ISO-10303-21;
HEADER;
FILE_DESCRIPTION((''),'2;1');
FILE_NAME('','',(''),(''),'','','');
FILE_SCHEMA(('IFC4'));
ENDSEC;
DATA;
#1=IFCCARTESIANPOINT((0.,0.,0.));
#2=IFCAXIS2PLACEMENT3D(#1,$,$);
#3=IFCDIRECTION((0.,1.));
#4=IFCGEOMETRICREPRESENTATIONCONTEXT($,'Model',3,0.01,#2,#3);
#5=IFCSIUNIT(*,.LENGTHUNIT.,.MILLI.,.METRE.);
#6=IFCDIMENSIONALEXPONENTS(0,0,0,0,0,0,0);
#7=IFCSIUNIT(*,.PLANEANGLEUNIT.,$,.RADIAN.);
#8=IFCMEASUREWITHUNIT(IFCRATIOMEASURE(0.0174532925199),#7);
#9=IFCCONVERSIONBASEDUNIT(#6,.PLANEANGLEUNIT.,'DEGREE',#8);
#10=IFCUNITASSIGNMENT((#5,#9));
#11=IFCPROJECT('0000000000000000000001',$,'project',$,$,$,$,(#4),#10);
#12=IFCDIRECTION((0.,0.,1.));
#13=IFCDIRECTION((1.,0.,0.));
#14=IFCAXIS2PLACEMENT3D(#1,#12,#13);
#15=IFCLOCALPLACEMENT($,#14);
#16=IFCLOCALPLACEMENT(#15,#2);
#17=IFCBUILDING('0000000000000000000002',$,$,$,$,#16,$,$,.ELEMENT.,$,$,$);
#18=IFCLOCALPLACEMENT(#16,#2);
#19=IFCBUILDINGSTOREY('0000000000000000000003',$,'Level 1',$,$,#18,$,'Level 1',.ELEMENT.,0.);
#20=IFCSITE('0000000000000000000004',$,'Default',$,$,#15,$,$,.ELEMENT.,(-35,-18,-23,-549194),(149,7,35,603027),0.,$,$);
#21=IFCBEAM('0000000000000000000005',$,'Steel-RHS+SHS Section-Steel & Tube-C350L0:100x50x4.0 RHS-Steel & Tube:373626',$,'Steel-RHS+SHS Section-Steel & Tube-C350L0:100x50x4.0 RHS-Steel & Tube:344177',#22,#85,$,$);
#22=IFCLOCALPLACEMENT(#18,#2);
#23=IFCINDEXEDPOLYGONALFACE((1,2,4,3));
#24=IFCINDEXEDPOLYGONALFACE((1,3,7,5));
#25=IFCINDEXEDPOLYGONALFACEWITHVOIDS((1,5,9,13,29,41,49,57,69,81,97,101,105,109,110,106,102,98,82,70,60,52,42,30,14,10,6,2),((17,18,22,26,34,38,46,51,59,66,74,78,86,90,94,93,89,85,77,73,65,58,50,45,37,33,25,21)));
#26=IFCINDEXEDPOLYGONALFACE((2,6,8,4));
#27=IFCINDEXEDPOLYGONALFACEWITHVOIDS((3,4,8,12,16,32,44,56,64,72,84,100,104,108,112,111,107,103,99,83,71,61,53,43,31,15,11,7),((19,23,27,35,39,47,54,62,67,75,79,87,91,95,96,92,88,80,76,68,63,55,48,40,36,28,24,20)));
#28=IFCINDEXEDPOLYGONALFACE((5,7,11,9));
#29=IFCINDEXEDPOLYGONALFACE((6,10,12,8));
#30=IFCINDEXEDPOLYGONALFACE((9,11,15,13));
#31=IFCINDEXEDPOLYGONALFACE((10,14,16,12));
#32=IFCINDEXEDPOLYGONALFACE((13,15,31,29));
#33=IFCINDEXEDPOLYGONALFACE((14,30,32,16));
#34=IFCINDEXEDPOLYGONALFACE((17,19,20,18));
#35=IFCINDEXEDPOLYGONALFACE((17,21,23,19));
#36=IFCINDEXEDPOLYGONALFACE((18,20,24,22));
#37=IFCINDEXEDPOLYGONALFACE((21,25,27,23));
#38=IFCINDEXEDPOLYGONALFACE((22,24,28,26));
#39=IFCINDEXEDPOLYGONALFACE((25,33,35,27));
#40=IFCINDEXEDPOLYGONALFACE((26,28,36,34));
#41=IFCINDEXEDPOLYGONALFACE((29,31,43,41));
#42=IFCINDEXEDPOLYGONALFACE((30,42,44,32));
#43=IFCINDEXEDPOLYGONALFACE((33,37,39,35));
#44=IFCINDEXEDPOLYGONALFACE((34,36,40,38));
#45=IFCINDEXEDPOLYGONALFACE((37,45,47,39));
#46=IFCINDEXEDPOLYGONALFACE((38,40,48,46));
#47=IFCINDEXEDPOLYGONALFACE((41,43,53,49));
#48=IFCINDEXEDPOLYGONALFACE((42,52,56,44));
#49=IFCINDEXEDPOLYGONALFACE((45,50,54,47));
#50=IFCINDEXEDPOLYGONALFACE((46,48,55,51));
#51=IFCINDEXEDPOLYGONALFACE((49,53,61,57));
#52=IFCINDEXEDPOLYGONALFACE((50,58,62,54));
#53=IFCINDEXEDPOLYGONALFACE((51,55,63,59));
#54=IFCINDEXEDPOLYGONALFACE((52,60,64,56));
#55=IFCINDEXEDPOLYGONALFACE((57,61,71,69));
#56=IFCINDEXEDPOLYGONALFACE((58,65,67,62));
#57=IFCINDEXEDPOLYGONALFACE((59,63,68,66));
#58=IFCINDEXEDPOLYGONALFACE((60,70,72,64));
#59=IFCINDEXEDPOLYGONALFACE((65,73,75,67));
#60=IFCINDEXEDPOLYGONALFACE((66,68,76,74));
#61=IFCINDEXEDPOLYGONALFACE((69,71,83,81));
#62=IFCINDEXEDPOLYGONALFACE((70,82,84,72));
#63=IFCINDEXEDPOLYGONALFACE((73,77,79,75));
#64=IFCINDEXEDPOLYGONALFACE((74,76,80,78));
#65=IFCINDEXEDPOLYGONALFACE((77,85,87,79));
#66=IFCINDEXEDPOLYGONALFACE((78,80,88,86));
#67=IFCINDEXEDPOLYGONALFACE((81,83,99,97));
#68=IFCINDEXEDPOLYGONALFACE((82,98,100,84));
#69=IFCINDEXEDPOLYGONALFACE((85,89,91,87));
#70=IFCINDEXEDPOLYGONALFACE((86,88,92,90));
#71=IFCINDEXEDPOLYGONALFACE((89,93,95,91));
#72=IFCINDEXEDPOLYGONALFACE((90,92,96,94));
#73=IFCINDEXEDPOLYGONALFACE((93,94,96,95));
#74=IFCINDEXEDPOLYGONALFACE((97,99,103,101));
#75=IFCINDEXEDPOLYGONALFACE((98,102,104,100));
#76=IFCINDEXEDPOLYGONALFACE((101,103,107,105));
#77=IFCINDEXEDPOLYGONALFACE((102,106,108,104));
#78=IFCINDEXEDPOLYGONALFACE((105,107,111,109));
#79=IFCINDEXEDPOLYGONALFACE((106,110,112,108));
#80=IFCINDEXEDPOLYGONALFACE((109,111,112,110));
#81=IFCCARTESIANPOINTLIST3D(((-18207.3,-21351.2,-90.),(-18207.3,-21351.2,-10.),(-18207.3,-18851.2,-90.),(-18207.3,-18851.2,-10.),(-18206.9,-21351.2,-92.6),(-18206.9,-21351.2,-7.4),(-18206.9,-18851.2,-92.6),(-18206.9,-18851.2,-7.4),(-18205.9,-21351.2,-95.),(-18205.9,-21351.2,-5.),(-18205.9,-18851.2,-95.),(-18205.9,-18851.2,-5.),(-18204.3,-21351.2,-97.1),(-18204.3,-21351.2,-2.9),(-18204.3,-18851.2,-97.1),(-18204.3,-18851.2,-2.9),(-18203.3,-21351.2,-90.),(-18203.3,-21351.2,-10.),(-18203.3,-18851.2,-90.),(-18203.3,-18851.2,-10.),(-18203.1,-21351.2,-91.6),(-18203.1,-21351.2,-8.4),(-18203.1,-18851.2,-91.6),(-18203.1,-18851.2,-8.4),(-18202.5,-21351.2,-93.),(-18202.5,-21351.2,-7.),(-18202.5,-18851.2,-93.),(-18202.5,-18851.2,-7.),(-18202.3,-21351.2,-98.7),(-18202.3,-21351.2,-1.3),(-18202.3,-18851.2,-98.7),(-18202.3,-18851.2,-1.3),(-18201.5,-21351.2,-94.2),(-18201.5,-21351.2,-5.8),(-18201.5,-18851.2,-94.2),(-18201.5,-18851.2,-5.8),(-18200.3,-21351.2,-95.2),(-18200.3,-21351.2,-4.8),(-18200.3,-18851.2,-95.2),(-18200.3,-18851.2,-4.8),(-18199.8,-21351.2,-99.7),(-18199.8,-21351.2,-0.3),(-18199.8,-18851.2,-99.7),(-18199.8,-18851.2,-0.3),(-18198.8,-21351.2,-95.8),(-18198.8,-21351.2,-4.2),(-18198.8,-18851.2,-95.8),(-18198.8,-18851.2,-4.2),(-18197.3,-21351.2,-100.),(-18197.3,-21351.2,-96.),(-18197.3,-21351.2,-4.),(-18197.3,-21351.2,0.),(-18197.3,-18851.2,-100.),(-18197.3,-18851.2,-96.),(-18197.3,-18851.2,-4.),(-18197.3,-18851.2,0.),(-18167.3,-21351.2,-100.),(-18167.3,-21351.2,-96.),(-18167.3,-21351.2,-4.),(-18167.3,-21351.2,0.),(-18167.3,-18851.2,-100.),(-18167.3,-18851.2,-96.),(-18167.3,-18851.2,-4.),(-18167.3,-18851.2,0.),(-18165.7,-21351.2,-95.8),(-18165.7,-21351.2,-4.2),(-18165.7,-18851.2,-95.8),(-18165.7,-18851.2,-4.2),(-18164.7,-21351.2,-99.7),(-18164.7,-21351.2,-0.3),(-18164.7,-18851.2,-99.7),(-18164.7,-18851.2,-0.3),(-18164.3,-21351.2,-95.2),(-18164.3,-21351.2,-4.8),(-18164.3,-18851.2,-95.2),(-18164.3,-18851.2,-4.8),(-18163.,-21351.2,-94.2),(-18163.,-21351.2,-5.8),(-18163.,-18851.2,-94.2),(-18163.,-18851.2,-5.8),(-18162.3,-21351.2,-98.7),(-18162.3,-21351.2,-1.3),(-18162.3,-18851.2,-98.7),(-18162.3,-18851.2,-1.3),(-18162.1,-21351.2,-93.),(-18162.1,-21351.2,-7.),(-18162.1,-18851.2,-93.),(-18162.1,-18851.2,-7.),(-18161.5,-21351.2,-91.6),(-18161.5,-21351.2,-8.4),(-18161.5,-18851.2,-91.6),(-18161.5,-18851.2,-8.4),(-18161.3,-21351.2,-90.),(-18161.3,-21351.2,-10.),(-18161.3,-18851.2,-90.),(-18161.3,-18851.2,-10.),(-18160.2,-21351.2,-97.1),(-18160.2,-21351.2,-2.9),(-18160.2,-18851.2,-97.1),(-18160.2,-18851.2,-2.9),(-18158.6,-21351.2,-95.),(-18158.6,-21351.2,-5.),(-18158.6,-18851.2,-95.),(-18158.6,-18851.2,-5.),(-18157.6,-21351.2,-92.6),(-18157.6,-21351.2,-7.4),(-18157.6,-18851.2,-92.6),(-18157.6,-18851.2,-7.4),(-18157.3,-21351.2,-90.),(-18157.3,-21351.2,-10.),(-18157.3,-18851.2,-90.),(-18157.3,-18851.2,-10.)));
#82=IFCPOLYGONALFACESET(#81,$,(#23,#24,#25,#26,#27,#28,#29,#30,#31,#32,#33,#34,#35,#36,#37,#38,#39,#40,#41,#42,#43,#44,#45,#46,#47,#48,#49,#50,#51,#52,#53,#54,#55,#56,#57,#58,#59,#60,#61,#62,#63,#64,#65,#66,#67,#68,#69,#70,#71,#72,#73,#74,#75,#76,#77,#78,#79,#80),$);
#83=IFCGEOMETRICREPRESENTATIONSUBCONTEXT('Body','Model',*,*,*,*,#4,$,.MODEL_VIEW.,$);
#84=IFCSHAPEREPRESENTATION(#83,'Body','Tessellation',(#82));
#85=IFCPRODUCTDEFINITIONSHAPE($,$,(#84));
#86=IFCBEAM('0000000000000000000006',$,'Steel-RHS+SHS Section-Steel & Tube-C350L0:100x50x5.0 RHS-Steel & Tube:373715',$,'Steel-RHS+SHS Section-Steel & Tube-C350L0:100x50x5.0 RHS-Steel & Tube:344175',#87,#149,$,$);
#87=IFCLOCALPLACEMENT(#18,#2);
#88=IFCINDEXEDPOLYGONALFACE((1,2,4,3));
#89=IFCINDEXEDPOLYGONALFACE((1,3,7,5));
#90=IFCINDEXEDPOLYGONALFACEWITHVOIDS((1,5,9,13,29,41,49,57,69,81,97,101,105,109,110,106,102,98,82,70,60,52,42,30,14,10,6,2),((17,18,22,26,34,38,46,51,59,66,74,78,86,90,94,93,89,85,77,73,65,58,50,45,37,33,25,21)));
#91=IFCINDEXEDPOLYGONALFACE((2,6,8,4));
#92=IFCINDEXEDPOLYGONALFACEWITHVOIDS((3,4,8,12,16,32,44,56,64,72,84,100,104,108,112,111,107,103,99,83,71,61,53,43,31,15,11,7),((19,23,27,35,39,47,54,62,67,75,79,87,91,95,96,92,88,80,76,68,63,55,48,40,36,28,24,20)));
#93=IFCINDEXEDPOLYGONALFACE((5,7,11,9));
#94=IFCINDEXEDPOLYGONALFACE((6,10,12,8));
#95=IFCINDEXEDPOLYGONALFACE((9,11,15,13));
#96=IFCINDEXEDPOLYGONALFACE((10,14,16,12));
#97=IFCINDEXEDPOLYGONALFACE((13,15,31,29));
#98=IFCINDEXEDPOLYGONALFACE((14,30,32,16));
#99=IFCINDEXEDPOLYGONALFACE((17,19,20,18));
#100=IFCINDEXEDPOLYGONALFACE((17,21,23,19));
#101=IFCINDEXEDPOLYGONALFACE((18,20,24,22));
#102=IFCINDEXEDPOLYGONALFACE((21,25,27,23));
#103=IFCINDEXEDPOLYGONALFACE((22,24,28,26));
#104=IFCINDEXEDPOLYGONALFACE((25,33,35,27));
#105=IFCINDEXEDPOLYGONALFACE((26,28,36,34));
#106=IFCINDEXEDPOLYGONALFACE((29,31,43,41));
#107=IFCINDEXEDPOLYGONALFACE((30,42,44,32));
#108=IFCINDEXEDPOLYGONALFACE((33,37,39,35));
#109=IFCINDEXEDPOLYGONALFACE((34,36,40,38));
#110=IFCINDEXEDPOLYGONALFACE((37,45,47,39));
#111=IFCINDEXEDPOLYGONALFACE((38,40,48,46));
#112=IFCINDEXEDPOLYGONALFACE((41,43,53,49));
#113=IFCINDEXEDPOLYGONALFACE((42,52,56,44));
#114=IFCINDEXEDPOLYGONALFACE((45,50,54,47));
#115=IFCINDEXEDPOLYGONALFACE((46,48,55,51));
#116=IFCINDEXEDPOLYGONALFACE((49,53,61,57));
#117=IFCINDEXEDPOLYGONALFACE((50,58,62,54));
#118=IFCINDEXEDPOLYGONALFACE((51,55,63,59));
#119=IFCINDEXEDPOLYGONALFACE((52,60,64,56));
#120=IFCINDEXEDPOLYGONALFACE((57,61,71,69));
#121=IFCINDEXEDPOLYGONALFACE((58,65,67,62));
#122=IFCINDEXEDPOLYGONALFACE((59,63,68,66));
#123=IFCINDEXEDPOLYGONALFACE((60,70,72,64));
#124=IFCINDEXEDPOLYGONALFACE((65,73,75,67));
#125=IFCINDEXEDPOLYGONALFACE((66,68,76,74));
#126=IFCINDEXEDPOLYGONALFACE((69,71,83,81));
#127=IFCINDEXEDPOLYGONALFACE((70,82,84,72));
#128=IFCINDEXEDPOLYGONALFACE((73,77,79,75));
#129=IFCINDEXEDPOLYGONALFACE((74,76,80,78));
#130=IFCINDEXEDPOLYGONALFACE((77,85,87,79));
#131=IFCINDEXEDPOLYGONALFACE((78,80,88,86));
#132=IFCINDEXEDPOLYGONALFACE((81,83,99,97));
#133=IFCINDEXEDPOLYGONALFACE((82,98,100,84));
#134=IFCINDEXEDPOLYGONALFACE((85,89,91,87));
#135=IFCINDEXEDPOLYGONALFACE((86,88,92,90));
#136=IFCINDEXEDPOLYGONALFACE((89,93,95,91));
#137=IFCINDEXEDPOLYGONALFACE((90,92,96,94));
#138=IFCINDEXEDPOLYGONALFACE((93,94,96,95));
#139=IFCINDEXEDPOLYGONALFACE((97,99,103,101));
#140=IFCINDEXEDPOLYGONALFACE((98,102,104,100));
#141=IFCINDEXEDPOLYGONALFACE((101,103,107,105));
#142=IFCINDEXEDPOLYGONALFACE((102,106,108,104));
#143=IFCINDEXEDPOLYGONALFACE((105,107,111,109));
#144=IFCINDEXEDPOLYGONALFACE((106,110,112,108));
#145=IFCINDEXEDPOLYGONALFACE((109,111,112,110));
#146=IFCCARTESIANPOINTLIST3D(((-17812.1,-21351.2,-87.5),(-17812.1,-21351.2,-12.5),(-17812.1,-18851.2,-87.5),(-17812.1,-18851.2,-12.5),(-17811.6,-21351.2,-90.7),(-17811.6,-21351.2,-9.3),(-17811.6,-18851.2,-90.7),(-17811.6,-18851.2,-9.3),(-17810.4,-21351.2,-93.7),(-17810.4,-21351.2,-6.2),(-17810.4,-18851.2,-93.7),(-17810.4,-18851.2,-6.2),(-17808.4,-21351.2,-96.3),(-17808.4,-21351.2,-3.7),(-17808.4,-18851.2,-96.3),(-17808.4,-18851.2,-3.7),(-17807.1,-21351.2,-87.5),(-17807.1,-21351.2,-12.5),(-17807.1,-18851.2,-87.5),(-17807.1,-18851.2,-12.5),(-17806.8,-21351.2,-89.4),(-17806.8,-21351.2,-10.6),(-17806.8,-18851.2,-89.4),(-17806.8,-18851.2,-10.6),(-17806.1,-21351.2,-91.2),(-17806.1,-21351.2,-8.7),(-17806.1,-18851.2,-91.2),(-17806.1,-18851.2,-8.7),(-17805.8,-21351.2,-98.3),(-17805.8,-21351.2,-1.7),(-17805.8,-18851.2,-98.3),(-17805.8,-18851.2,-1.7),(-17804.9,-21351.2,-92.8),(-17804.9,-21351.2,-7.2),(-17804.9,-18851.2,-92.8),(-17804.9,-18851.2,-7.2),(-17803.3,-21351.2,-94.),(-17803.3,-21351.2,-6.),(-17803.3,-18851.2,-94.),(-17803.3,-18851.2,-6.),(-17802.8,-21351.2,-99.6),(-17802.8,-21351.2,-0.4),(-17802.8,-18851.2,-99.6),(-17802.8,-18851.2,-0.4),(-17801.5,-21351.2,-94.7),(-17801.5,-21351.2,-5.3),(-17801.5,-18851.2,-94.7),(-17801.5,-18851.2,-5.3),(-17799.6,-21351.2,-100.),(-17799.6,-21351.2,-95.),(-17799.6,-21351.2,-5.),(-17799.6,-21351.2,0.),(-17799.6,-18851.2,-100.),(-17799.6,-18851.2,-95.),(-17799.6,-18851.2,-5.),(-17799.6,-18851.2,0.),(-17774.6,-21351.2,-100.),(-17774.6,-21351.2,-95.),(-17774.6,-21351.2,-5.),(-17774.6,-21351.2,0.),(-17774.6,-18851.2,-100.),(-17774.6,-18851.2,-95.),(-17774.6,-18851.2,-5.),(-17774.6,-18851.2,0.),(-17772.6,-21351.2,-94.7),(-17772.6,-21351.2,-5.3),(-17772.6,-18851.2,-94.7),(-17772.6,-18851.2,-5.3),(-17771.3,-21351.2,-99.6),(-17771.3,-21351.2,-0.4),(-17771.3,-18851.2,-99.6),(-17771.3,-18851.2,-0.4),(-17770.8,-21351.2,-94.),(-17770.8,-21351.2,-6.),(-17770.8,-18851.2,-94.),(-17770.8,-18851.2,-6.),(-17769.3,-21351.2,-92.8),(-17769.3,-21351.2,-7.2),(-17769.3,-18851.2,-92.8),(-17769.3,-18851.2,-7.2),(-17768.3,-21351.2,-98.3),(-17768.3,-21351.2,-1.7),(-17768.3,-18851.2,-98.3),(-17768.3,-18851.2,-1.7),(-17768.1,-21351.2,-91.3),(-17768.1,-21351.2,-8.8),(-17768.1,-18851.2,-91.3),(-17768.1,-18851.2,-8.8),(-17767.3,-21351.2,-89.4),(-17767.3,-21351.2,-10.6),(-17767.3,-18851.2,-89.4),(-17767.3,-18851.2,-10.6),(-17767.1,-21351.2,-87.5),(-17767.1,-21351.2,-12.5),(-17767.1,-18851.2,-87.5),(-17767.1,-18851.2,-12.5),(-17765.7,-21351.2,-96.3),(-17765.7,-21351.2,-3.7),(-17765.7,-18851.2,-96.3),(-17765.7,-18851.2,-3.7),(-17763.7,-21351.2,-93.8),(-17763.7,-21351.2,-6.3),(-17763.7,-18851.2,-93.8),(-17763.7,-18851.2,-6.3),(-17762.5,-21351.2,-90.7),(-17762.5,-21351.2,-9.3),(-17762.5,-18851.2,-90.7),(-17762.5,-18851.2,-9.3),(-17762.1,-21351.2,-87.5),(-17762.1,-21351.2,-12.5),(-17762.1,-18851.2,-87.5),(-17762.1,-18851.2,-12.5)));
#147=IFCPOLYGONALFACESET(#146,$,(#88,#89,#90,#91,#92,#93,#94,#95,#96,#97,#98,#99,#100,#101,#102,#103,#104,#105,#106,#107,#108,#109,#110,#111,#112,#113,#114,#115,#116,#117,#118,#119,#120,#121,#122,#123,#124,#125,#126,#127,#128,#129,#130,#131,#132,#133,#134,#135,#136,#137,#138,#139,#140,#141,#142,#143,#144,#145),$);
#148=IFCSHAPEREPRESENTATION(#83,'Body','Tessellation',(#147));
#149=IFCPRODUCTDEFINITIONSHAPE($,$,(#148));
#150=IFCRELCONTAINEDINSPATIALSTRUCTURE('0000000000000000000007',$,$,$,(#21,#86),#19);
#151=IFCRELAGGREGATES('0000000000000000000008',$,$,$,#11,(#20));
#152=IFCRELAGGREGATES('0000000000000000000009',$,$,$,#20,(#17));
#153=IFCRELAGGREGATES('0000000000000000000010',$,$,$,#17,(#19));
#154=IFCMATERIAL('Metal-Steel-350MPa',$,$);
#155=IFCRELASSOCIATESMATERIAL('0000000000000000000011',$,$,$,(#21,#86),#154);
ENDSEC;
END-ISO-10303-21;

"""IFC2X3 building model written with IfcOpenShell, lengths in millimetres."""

from ifc_helpers import new_model, entity, si_unit, converted_unit, direction, frame, frame_2d, origin, origin_with_axes, place, context, subcontext, project, spatial, polyline, circle_curve, parameter, trimmed, segment, composite_curve, outline, extrude, material, element, save


model = new_model("IFC2X3")

# Units and contexts
model_context = context("Model", 3, precision=0.01, world=origin(), true_north=direction((0.0, 1.0)))
body_context = subcontext(model_context, "Body", "Model", "MODEL_VIEW")
ifc_project = project(units=[si_unit("LENGTHUNIT", "METRE", prefix="MILLI"), converted_unit("PLANEANGLEUNIT", "DEGREE", entity("IfcRatioMeasure", 0.0174532925199), si_unit("PLANEANGLEUNIT", "RADIAN"), dimensions=[0, 0, 0, 0, 0, 0, 0])], contexts=[model_context])

# Site, building, storey
site_placement = place(None, origin_with_axes())
site = spatial("IfcSite", under=ifc_project, at=site_placement, Name="Default", CompositionType="ELEMENT", RefLatitude=(-35, -18, -23, -549194), RefLongitude=(149, 7, 35, 603027), RefElevation=0.0)
building_placement = place(site_placement, origin())
building = spatial("IfcBuilding", under=site, at=building_placement, CompositionType="ELEMENT")
storey_placement = place(building_placement, origin())
storey = spatial("IfcBuildingStorey", under=building, at=storey_placement, Name="Level 1", LongName="Level 1", CompositionType="ELEMENT", Elevation=0.0)

# Beams
ifc_material = material(Name="Metal-Steel-350MPa")
beam_1_placement = place(storey_placement, frame((-18182.3, -18851.2, 0.0), z_axis=(0.0, 0.0, 1.0), x_axis=(0.0, -1.0, 0.0)))
element("IfcBeam", 1, at=beam_1_placement, inside=storey, material=ifc_material, Name="Steel-RHS+SHS Section-Steel & Tube-C350L0:100x50x4.0 RHS-Steel & Tube:373626", ObjectType="Steel-RHS+SHS Section-Steel & Tube-C350L0:100x50x4.0 RHS-Steel & Tube:344177", context=body_context, shape_type="SweptSolid", body=[
    extrude(outline(composite_curve([segment(trimmed(circle_curve(frame_2d((-15.0, -40.0), x_axis=(1.0, 0.0)), 10.0), [parameter(180.0)], [parameter(270.0)], True, "PARAMETER"), True, "CONTINUOUS"), segment(polyline([(-15.0, -50.0), (15.0, -50.0)]), True, "CONTINUOUS"), segment(trimmed(circle_curve(frame_2d((15.0, -40.0), x_axis=(1.0, 0.0)), 10.0), [parameter(270.0)], [parameter(0.0)], True, "PARAMETER"), True, "CONTINUOUS"), segment(polyline([(25.0, -40.0), (25.0, 40.0)]), True, "CONTINUOUS"), segment(trimmed(circle_curve(frame_2d((15.0, 40.0), x_axis=(1.0, 0.0)), 10.0), [parameter(0.0)], [parameter(90.0)], True, "PARAMETER"), True, "CONTINUOUS"), segment(polyline([(15.0, 50.0), (-15.0, 50.0)]), True, "CONTINUOUS"), segment(trimmed(circle_curve(frame_2d((-15.0, 40.0), x_axis=(1.0, 0.0)), 10.0), [parameter(90.0)], [parameter(180.0)], True, "PARAMETER"), True, "CONTINUOUS"), segment(polyline([(-25.0, 40.0), (-25.0, -40.0)]), True, "CONTINUOUS")], self_intersect=False), holes=[composite_curve([segment(polyline([(15.0, -46.0), (-15.0, -46.0)]), True, "CONTINUOUS"), segment(trimmed(circle_curve(frame_2d((-15.0, -40.0), x_axis=(1.0, 0.0)), 6.0), [parameter(180.0)], [parameter(270.0)], True, "PARAMETER"), False, "CONTINUOUS"), segment(polyline([(-21.0, -40.0), (-21.0, 40.0)]), True, "CONTINUOUS"), segment(trimmed(circle_curve(frame_2d((-15.0, 40.0), x_axis=(1.0, 0.0)), 6.0), [parameter(90.0)], [parameter(180.0)], True, "PARAMETER"), False, "CONTINUOUS"), segment(polyline([(-15.0, 46.0), (15.0, 46.0)]), True, "CONTINUOUS"), segment(trimmed(circle_curve(frame_2d((15.0, 40.0), x_axis=(1.0, 0.0)), 6.0), [parameter(360.0)], [parameter(90.0)], True, "PARAMETER"), False, "CONTINUOUS"), segment(polyline([(21.0, 40.0), (21.0, -40.0)]), True, "CONTINUOUS"), segment(trimmed(circle_curve(frame_2d((15.0, -40.0), x_axis=(1.0, 0.0)), 6.0), [parameter(270.0)], [parameter(0.0)], True, "PARAMETER"), False, "CONTINUOUS")], self_intersect=False)]), frame((0.0, 0.0, -50.0), z_axis=(1.0, 0.0, 0.0), x_axis=(0.0, -1.0, 0.0)), (0.0, 0.0, 1.0), 2500.0),
])
beam_2_placement = place(storey_placement, frame((-17787.1, -18851.2, 0.0), z_axis=(0.0, 0.0, 1.0), x_axis=(0.0, -1.0, 0.0)))
element("IfcBeam", 2, at=beam_2_placement, inside=storey, material=ifc_material, Name="Steel-RHS+SHS Section-Steel & Tube-C350L0:100x50x5.0 RHS-Steel & Tube:373715", ObjectType="Steel-RHS+SHS Section-Steel & Tube-C350L0:100x50x5.0 RHS-Steel & Tube:344175", context=body_context, shape_type="SweptSolid", body=[
    extrude(outline(composite_curve([segment(trimmed(circle_curve(frame_2d((-12.5, -37.5), x_axis=(1.0, 0.0)), 12.5), [parameter(180.0)], [parameter(270.0)], True, "PARAMETER"), True, "CONTINUOUS"), segment(polyline([(-12.5, -50.0), (12.5, -50.0)]), True, "CONTINUOUS"), segment(trimmed(circle_curve(frame_2d((12.5, -37.5), x_axis=(1.0, 0.0)), 12.5), [parameter(270.0)], [parameter(0.0)], True, "PARAMETER"), True, "CONTINUOUS"), segment(polyline([(25.0, -37.5), (25.0, 37.5)]), True, "CONTINUOUS"), segment(trimmed(circle_curve(frame_2d((12.5, 37.5), x_axis=(1.0, 0.0)), 12.5), [parameter(0.0)], [parameter(90.0)], True, "PARAMETER"), True, "CONTINUOUS"), segment(polyline([(12.5, 50.0), (-12.5, 50.0)]), True, "CONTINUOUS"), segment(trimmed(circle_curve(frame_2d((-12.5, 37.5), x_axis=(1.0, 0.0)), 12.5), [parameter(90.0)], [parameter(180.0)], True, "PARAMETER"), True, "CONTINUOUS"), segment(polyline([(-25.0, 37.5), (-25.0, -37.5)]), True, "CONTINUOUS")], self_intersect=False), holes=[composite_curve([segment(polyline([(12.5, -45.0), (-12.5, -45.0)]), True, "CONTINUOUS"), segment(trimmed(circle_curve(frame_2d((-12.5, -37.5), x_axis=(1.0, 0.0)), 7.5), [parameter(180.0)], [parameter(270.0)], True, "PARAMETER"), False, "CONTINUOUS"), segment(polyline([(-20.0, -37.5), (-20.0, 37.5)]), True, "CONTINUOUS"), segment(trimmed(circle_curve(frame_2d((-12.5, 37.5), x_axis=(1.0, 0.0)), 7.5), [parameter(90.0)], [parameter(180.0)], True, "PARAMETER"), False, "CONTINUOUS"), segment(polyline([(-12.5, 45.0), (12.5, 45.0)]), True, "CONTINUOUS"), segment(trimmed(circle_curve(frame_2d((12.5, 37.5), x_axis=(1.0, 0.0)), 7.5), [parameter(360.0)], [parameter(90.0)], True, "PARAMETER"), False, "CONTINUOUS"), segment(polyline([(20.0, 37.5), (20.0, -37.5)]), True, "CONTINUOUS"), segment(trimmed(circle_curve(frame_2d((12.5, -37.5), x_axis=(1.0, 0.0)), 7.5), [parameter(270.0)], [parameter(360.0)], True, "PARAMETER"), False, "CONTINUOUS")], self_intersect=False)]), frame((0.0, 0.0, -50.0), z_axis=(1.0, 0.0, 0.0), x_axis=(0.0, -1.0, 0.0)), (0.0, 0.0, 1.0), 2500.0),
])

save(model, "model.ifc")
